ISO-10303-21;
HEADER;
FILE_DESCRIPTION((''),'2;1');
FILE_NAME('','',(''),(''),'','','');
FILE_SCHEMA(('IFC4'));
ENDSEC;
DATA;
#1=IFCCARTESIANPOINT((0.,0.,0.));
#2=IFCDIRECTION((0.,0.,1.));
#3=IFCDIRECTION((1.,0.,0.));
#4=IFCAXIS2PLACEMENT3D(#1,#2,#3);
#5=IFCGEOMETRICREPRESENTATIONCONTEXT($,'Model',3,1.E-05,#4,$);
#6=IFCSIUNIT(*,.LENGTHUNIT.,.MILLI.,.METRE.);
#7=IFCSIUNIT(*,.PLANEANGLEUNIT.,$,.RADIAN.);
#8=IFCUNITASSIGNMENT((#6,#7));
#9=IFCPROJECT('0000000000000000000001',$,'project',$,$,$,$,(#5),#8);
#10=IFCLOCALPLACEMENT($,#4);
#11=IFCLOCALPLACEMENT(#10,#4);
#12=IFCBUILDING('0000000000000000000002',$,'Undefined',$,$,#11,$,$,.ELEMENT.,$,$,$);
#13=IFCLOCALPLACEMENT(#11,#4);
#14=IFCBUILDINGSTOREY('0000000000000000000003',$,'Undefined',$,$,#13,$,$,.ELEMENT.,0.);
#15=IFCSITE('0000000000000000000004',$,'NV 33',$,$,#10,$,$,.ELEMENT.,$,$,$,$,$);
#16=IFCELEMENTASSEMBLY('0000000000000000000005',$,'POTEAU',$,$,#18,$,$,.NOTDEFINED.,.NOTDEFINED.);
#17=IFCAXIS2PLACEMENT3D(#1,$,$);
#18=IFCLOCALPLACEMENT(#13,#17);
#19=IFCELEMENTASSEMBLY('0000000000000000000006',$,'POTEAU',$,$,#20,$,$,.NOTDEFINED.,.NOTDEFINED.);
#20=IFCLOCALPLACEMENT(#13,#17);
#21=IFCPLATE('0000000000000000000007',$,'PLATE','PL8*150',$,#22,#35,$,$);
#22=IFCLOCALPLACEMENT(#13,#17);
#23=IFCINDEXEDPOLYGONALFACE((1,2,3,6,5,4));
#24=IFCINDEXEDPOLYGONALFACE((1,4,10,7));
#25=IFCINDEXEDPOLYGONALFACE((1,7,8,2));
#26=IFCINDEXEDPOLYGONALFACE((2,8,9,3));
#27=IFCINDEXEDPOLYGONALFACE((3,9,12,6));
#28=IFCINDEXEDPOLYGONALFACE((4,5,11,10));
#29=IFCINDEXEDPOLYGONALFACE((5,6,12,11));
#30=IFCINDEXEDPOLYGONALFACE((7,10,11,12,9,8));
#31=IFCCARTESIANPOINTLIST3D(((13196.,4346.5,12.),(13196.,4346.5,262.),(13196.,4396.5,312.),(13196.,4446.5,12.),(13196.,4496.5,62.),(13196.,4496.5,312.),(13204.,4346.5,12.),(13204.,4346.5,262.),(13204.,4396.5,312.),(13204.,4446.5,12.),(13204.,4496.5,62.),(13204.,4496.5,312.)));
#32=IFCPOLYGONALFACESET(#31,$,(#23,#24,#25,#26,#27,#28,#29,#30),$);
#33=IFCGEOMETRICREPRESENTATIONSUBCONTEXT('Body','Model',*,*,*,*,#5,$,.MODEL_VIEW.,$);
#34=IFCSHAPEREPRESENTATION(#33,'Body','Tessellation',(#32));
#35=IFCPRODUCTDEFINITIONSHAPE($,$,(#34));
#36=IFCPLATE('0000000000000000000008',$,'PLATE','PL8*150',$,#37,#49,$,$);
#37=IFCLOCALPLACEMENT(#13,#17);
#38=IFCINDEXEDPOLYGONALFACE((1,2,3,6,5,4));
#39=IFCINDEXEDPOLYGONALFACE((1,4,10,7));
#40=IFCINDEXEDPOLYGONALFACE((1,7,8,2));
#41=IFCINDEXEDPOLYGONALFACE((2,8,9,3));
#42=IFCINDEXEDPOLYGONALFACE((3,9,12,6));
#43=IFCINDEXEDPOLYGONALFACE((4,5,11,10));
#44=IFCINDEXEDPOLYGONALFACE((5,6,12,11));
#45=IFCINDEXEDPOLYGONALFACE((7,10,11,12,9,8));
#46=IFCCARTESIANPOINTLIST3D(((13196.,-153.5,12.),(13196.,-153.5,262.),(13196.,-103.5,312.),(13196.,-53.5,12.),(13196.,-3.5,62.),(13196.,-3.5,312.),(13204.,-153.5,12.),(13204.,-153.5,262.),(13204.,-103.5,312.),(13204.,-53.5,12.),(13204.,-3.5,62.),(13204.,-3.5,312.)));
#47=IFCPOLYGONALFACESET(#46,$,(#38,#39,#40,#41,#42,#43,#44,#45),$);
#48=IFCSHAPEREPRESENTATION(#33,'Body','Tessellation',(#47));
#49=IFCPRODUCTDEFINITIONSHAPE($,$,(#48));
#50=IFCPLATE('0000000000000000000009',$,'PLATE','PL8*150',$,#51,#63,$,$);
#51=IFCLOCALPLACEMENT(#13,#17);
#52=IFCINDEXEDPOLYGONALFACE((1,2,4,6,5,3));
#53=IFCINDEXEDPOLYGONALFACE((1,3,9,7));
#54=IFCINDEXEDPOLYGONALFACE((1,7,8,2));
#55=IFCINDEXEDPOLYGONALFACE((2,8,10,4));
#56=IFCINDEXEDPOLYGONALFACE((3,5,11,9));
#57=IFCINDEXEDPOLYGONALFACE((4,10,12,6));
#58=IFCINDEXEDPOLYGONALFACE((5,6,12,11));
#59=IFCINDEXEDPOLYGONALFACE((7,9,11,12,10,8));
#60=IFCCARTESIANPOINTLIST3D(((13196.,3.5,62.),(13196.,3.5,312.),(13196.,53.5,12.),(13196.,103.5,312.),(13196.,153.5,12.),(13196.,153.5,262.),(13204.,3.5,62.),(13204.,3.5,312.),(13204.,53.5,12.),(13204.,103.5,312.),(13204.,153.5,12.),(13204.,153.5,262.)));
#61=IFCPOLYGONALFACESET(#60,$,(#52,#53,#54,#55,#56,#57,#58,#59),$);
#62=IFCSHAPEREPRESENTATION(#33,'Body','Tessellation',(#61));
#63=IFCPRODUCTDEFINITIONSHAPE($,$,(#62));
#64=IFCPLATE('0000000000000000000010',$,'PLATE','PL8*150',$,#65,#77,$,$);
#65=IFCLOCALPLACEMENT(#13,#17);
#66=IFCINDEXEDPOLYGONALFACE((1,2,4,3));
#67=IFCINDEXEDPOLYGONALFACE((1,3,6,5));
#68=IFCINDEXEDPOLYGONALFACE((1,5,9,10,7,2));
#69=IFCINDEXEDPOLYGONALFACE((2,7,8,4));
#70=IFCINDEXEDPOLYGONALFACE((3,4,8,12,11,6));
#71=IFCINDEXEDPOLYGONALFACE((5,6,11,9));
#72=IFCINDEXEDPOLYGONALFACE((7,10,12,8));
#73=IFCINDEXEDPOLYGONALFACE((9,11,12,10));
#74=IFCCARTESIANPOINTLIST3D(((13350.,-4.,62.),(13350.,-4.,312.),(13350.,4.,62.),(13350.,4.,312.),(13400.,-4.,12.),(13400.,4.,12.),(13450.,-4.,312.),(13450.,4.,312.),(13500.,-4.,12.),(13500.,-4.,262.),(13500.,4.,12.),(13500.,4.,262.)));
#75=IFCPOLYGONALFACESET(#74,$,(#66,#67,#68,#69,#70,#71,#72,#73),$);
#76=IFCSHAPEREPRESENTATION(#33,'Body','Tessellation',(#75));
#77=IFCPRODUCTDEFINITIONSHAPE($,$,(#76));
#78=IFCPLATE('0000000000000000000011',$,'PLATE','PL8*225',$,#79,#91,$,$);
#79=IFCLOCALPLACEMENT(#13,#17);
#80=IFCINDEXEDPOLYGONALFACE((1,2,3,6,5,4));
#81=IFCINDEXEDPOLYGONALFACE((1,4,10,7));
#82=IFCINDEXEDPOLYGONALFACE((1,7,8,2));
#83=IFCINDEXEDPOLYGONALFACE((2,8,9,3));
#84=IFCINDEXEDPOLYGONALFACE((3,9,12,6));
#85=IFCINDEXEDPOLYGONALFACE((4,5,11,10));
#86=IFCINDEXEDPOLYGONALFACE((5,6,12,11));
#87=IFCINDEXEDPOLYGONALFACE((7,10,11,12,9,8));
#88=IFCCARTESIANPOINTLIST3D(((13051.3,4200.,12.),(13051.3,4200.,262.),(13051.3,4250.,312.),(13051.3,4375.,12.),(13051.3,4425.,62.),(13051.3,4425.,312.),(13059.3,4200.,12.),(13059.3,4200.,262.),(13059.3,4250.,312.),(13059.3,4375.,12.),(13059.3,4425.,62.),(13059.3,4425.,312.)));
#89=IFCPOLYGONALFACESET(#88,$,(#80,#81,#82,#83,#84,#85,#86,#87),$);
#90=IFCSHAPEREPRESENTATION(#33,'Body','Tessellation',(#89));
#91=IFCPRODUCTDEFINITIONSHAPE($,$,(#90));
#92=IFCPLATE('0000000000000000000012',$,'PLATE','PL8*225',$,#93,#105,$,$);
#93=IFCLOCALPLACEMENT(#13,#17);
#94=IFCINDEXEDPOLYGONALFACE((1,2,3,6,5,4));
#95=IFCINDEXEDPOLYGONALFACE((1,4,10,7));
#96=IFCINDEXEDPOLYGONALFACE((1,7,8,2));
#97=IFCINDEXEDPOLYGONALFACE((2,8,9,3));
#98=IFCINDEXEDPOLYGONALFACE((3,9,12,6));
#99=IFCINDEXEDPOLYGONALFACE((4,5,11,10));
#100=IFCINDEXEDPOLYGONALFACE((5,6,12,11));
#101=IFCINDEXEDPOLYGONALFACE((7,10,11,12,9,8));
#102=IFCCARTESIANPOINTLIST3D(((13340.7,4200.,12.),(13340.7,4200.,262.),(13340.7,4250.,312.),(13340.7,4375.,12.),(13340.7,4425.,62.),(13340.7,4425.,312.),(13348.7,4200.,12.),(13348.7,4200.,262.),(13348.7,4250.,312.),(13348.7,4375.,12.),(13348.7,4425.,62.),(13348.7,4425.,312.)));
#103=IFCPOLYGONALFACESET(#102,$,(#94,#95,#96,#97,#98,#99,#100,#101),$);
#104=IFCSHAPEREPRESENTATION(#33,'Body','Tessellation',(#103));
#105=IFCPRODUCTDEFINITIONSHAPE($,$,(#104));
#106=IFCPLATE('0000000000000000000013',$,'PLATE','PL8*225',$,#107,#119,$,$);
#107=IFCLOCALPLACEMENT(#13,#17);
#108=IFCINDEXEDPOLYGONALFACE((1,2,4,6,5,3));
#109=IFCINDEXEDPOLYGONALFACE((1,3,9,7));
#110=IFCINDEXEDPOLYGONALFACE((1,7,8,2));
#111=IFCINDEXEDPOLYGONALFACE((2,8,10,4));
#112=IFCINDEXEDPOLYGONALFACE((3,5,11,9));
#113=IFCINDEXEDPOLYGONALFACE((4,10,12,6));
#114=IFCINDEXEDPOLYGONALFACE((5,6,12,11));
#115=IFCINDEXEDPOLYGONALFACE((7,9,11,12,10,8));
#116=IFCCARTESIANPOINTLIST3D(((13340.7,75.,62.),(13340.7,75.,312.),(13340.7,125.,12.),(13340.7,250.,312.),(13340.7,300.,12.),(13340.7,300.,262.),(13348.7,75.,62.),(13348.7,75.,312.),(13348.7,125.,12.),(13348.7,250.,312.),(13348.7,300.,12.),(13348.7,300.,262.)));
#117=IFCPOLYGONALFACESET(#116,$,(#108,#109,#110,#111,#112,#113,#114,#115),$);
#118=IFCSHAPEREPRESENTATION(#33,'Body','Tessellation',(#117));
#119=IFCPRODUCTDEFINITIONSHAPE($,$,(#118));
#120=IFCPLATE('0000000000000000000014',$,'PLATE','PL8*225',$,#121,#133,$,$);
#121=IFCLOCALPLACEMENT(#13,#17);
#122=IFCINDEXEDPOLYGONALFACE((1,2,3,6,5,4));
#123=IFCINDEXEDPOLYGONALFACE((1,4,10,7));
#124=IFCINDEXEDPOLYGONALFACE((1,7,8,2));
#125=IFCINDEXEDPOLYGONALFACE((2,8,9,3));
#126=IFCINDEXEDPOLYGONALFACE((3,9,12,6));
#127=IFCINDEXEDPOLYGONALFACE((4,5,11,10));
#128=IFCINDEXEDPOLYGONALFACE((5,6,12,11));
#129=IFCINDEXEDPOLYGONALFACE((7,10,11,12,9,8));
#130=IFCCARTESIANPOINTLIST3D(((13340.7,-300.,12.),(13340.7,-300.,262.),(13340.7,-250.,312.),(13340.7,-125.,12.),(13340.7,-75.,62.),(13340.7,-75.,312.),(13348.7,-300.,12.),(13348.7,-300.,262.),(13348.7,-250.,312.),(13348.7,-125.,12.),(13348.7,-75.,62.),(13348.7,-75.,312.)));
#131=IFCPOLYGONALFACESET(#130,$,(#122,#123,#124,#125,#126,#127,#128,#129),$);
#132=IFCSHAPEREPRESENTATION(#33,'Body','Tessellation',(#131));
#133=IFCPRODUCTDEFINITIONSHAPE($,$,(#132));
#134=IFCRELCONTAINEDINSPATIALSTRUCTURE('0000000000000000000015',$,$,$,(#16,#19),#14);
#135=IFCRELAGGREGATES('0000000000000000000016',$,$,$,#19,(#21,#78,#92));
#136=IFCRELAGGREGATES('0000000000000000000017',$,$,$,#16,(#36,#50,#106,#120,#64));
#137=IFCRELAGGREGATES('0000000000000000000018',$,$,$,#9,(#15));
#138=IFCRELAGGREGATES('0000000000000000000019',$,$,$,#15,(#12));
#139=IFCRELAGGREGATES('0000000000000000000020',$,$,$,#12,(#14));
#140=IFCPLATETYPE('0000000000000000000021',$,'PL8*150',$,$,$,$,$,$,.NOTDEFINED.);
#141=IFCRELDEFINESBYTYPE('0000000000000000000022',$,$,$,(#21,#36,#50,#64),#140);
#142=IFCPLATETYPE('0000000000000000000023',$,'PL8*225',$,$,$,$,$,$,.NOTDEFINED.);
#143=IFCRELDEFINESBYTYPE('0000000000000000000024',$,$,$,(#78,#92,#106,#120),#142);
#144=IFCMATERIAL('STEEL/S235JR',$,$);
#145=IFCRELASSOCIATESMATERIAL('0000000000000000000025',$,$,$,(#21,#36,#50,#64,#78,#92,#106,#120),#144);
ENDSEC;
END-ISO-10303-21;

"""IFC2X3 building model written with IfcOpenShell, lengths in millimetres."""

from ifc_helpers import new_model, si_unit, frame, origin_with_axes, place, context, subcontext, project, spatial, polyline, outline, extrude, material, type_object, element, aggregate, save


model = new_model("IFC2X3")

# Units and contexts
model_context = context("Model", 3, precision=1e-05, world=origin_with_axes())
body_context = subcontext(model_context, "Body", "Model", "MODEL_VIEW")
ifc_project = project(units=[si_unit("LENGTHUNIT", "METRE", prefix="MILLI"), si_unit("PLANEANGLEUNIT", "RADIAN")], contexts=[model_context])

# Site, building, storey
site_placement = place(None, origin_with_axes())
site = spatial("IfcSite", under=ifc_project, at=site_placement, Name="NV 33", CompositionType="ELEMENT")
building_placement = place(site_placement, origin_with_axes())
building = spatial("IfcBuilding", under=site, at=building_placement, Name="Undefined", CompositionType="ELEMENT")
storey_placement = place(building_placement, origin_with_axes())
storey = spatial("IfcBuildingStorey", under=building, at=storey_placement, Name="Undefined", CompositionType="ELEMENT", Elevation=0.0)

# Element assembly
assembly_1_placement = place(storey_placement, origin_with_axes())
assembly_1 = element("IfcElementAssembly", 1, at=assembly_1_placement, inside=storey, Name="POTEAU", AssemblyPlace="NOTDEFINED", PredefinedType="NOTDEFINED")
ifc_material_1 = material(Name="STEEL/S235JR")

# Element assembly
assembly_2_placement = place(storey_placement, origin_with_axes())
assembly_2 = element("IfcElementAssembly", 2, at=assembly_2_placement, inside=storey, Name="POTEAU", AssemblyPlace="NOTDEFINED", PredefinedType="NOTDEFINED")

# Plates
plate_type_1 = type_object("IfcPlateType", Name="PL8*150", PredefinedType="NOTDEFINED")
plate_1_placement = place(assembly_2_placement, frame((13200.0, 4496.5, 12.0), z_axis=(-1.0, 0.0, 0.0), x_axis=(0.0, -1.0, 0.0)))
plate_1 = element("IfcPlate", 3, at=plate_1_placement, type_object=plate_type_1, material=ifc_material_1, Name="PLATE", Description="PL8*150", context=body_context, shape_type="SweptSolid", body=[
    extrude(outline(polyline([(0.0, 50.0), (50.0, 0.0), (150.0, 0.0), (150.0, 250.0), (100.0, 300.0), (0.0, 300.0), (0.0, 50.0)])), frame((0.0, 0.0, -4.0), z_axis=(0.0, 0.0, 1.0), x_axis=(1.0, 0.0, 0.0)), (0.0, 0.0, 1.0), 8.0),
])
plate_2_placement = place(assembly_1_placement, frame((13200.0, -3.5, 12.0), z_axis=(-1.0, 0.0, 0.0), x_axis=(0.0, -1.0, 0.0)))
plate_2 = element("IfcPlate", 4, at=plate_2_placement, type_object=plate_type_1, material=ifc_material_1, Name="PLATE", Description="PL8*150", context=body_context, shape_type="SweptSolid", body=[
    extrude(outline(polyline([(0.0, 50.0), (50.0, 0.0), (150.0, 0.0), (150.0, 250.0), (100.0, 300.0), (0.0, 300.0), (0.0, 50.0)])), frame((0.0, 0.0, -4.0), z_axis=(0.0, 0.0, 1.0), x_axis=(1.0, 0.0, 0.0)), (0.0, 0.0, 1.0), 8.0),
])
plate_3_placement = place(assembly_1_placement, frame((13200.0, 3.5, 12.0), z_axis=(1.0, 0.0, 0.0), x_axis=(0.0, 1.0, 0.0)))
plate_3 = element("IfcPlate", 5, at=plate_3_placement, type_object=plate_type_1, material=ifc_material_1, Name="PLATE", Description="PL8*150", context=body_context, shape_type="SweptSolid", body=[
    extrude(outline(polyline([(0.0, 50.0), (50.0, 0.0), (150.0, 0.0), (150.0, 250.0), (100.0, 300.0), (0.0, 300.0), (0.0, 50.0)])), frame((0.0, 0.0, -4.0), z_axis=(0.0, 0.0, 1.0), x_axis=(1.0, 0.0, 0.0)), (0.0, 0.0, 1.0), 8.0),
])
plate_4_placement = place(assembly_1_placement, frame((13350.0, 0.0, 12.0), z_axis=(0.0, -1.0, 0.0), x_axis=(1.0, 0.0, 0.0)))
plate_4 = element("IfcPlate", 6, at=plate_4_placement, type_object=plate_type_1, material=ifc_material_1, Name="PLATE", Description="PL8*150", context=body_context, shape_type="SweptSolid", body=[
    extrude(outline(polyline([(0.0, 50.0), (50.0, 0.0), (150.0, 0.0), (150.0, 250.0), (100.0, 300.0), (0.0, 300.0), (0.0, 50.0)])), frame((0.0, 0.0, -4.0), z_axis=(0.0, 0.0, 1.0), x_axis=(1.0, 0.0, 0.0)), (0.0, 0.0, 1.0), 8.0),
])
plate_type_2 = type_object("IfcPlateType", Name="PL8*225", PredefinedType="NOTDEFINED")
plate_5_placement = place(assembly_2_placement, frame((13055.3, 4425.0, 12.0), z_axis=(-1.0, 0.0, 0.0), x_axis=(0.0, -1.0, 0.0)))
plate_5 = element("IfcPlate", 7, at=plate_5_placement, type_object=plate_type_2, material=ifc_material_1, Name="PLATE", Description="PL8*225", context=body_context, shape_type="SweptSolid", body=[
    extrude(outline(polyline([(0.0, 50.0), (50.0, 0.0), (225.0, 0.0), (225.0, 250.0), (175.0, 300.0), (0.0, 300.0), (0.0, 50.0)])), frame((0.0, 0.0, -4.0), z_axis=(0.0, 0.0, 1.0), x_axis=(1.0, 0.0, 0.0)), (0.0, 0.0, 1.0), 8.0),
])
plate_6_placement = place(assembly_2_placement, frame((13344.7, 4425.0, 12.0), z_axis=(-1.0, 0.0, 0.0), x_axis=(0.0, -1.0, 0.0)))
plate_6 = element("IfcPlate", 8, at=plate_6_placement, type_object=plate_type_2, material=ifc_material_1, Name="PLATE", Description="PL8*225", context=body_context, shape_type="SweptSolid", body=[
    extrude(outline(polyline([(0.0, 50.0), (50.0, 0.0), (225.0, 0.0), (225.0, 250.0), (175.0, 300.0), (0.0, 300.0), (0.0, 50.0)])), frame((0.0, 0.0, -4.0), z_axis=(0.0, 0.0, 1.0), x_axis=(1.0, 0.0, 0.0)), (0.0, 0.0, 1.0), 8.0),
])
aggregate(assembly_2, [plate_1, plate_5, plate_6])
plate_7_placement = place(assembly_1_placement, frame((13344.7, 75.0, 12.0), z_axis=(1.0, 0.0, 0.0), x_axis=(0.0, 1.0, 0.0)))
plate_7 = element("IfcPlate", 9, at=plate_7_placement, type_object=plate_type_2, material=ifc_material_1, Name="PLATE", Description="PL8*225", context=body_context, shape_type="SweptSolid", body=[
    extrude(outline(polyline([(0.0, 50.0), (50.0, 0.0), (225.0, 0.0), (225.0, 250.0), (175.0, 300.0), (0.0, 300.0), (0.0, 50.0)])), frame((0.0, 0.0, -4.0), z_axis=(0.0, 0.0, 1.0), x_axis=(1.0, 0.0, 0.0)), (0.0, 0.0, 1.0), 8.0),
])
plate_8_placement = place(assembly_1_placement, frame((13344.7, -75.0, 12.0), z_axis=(-1.0, 0.0, 0.0), x_axis=(0.0, -1.0, 0.0)))
plate_8 = element("IfcPlate", 10, at=plate_8_placement, type_object=plate_type_2, material=ifc_material_1, Name="PLATE", Description="PL8*225", context=body_context, shape_type="SweptSolid", body=[
    extrude(outline(polyline([(0.0, 50.0), (50.0, 0.0), (225.0, 0.0), (225.0, 250.0), (175.0, 300.0), (0.0, 300.0), (0.0, 50.0)])), frame((0.0, 0.0, -4.0), z_axis=(0.0, 0.0, 1.0), x_axis=(1.0, 0.0, 0.0)), (0.0, 0.0, 1.0), 8.0),
])
aggregate(assembly_1, [plate_2, plate_3, plate_7, plate_8, plate_4])

save(model, "model.ifc")
